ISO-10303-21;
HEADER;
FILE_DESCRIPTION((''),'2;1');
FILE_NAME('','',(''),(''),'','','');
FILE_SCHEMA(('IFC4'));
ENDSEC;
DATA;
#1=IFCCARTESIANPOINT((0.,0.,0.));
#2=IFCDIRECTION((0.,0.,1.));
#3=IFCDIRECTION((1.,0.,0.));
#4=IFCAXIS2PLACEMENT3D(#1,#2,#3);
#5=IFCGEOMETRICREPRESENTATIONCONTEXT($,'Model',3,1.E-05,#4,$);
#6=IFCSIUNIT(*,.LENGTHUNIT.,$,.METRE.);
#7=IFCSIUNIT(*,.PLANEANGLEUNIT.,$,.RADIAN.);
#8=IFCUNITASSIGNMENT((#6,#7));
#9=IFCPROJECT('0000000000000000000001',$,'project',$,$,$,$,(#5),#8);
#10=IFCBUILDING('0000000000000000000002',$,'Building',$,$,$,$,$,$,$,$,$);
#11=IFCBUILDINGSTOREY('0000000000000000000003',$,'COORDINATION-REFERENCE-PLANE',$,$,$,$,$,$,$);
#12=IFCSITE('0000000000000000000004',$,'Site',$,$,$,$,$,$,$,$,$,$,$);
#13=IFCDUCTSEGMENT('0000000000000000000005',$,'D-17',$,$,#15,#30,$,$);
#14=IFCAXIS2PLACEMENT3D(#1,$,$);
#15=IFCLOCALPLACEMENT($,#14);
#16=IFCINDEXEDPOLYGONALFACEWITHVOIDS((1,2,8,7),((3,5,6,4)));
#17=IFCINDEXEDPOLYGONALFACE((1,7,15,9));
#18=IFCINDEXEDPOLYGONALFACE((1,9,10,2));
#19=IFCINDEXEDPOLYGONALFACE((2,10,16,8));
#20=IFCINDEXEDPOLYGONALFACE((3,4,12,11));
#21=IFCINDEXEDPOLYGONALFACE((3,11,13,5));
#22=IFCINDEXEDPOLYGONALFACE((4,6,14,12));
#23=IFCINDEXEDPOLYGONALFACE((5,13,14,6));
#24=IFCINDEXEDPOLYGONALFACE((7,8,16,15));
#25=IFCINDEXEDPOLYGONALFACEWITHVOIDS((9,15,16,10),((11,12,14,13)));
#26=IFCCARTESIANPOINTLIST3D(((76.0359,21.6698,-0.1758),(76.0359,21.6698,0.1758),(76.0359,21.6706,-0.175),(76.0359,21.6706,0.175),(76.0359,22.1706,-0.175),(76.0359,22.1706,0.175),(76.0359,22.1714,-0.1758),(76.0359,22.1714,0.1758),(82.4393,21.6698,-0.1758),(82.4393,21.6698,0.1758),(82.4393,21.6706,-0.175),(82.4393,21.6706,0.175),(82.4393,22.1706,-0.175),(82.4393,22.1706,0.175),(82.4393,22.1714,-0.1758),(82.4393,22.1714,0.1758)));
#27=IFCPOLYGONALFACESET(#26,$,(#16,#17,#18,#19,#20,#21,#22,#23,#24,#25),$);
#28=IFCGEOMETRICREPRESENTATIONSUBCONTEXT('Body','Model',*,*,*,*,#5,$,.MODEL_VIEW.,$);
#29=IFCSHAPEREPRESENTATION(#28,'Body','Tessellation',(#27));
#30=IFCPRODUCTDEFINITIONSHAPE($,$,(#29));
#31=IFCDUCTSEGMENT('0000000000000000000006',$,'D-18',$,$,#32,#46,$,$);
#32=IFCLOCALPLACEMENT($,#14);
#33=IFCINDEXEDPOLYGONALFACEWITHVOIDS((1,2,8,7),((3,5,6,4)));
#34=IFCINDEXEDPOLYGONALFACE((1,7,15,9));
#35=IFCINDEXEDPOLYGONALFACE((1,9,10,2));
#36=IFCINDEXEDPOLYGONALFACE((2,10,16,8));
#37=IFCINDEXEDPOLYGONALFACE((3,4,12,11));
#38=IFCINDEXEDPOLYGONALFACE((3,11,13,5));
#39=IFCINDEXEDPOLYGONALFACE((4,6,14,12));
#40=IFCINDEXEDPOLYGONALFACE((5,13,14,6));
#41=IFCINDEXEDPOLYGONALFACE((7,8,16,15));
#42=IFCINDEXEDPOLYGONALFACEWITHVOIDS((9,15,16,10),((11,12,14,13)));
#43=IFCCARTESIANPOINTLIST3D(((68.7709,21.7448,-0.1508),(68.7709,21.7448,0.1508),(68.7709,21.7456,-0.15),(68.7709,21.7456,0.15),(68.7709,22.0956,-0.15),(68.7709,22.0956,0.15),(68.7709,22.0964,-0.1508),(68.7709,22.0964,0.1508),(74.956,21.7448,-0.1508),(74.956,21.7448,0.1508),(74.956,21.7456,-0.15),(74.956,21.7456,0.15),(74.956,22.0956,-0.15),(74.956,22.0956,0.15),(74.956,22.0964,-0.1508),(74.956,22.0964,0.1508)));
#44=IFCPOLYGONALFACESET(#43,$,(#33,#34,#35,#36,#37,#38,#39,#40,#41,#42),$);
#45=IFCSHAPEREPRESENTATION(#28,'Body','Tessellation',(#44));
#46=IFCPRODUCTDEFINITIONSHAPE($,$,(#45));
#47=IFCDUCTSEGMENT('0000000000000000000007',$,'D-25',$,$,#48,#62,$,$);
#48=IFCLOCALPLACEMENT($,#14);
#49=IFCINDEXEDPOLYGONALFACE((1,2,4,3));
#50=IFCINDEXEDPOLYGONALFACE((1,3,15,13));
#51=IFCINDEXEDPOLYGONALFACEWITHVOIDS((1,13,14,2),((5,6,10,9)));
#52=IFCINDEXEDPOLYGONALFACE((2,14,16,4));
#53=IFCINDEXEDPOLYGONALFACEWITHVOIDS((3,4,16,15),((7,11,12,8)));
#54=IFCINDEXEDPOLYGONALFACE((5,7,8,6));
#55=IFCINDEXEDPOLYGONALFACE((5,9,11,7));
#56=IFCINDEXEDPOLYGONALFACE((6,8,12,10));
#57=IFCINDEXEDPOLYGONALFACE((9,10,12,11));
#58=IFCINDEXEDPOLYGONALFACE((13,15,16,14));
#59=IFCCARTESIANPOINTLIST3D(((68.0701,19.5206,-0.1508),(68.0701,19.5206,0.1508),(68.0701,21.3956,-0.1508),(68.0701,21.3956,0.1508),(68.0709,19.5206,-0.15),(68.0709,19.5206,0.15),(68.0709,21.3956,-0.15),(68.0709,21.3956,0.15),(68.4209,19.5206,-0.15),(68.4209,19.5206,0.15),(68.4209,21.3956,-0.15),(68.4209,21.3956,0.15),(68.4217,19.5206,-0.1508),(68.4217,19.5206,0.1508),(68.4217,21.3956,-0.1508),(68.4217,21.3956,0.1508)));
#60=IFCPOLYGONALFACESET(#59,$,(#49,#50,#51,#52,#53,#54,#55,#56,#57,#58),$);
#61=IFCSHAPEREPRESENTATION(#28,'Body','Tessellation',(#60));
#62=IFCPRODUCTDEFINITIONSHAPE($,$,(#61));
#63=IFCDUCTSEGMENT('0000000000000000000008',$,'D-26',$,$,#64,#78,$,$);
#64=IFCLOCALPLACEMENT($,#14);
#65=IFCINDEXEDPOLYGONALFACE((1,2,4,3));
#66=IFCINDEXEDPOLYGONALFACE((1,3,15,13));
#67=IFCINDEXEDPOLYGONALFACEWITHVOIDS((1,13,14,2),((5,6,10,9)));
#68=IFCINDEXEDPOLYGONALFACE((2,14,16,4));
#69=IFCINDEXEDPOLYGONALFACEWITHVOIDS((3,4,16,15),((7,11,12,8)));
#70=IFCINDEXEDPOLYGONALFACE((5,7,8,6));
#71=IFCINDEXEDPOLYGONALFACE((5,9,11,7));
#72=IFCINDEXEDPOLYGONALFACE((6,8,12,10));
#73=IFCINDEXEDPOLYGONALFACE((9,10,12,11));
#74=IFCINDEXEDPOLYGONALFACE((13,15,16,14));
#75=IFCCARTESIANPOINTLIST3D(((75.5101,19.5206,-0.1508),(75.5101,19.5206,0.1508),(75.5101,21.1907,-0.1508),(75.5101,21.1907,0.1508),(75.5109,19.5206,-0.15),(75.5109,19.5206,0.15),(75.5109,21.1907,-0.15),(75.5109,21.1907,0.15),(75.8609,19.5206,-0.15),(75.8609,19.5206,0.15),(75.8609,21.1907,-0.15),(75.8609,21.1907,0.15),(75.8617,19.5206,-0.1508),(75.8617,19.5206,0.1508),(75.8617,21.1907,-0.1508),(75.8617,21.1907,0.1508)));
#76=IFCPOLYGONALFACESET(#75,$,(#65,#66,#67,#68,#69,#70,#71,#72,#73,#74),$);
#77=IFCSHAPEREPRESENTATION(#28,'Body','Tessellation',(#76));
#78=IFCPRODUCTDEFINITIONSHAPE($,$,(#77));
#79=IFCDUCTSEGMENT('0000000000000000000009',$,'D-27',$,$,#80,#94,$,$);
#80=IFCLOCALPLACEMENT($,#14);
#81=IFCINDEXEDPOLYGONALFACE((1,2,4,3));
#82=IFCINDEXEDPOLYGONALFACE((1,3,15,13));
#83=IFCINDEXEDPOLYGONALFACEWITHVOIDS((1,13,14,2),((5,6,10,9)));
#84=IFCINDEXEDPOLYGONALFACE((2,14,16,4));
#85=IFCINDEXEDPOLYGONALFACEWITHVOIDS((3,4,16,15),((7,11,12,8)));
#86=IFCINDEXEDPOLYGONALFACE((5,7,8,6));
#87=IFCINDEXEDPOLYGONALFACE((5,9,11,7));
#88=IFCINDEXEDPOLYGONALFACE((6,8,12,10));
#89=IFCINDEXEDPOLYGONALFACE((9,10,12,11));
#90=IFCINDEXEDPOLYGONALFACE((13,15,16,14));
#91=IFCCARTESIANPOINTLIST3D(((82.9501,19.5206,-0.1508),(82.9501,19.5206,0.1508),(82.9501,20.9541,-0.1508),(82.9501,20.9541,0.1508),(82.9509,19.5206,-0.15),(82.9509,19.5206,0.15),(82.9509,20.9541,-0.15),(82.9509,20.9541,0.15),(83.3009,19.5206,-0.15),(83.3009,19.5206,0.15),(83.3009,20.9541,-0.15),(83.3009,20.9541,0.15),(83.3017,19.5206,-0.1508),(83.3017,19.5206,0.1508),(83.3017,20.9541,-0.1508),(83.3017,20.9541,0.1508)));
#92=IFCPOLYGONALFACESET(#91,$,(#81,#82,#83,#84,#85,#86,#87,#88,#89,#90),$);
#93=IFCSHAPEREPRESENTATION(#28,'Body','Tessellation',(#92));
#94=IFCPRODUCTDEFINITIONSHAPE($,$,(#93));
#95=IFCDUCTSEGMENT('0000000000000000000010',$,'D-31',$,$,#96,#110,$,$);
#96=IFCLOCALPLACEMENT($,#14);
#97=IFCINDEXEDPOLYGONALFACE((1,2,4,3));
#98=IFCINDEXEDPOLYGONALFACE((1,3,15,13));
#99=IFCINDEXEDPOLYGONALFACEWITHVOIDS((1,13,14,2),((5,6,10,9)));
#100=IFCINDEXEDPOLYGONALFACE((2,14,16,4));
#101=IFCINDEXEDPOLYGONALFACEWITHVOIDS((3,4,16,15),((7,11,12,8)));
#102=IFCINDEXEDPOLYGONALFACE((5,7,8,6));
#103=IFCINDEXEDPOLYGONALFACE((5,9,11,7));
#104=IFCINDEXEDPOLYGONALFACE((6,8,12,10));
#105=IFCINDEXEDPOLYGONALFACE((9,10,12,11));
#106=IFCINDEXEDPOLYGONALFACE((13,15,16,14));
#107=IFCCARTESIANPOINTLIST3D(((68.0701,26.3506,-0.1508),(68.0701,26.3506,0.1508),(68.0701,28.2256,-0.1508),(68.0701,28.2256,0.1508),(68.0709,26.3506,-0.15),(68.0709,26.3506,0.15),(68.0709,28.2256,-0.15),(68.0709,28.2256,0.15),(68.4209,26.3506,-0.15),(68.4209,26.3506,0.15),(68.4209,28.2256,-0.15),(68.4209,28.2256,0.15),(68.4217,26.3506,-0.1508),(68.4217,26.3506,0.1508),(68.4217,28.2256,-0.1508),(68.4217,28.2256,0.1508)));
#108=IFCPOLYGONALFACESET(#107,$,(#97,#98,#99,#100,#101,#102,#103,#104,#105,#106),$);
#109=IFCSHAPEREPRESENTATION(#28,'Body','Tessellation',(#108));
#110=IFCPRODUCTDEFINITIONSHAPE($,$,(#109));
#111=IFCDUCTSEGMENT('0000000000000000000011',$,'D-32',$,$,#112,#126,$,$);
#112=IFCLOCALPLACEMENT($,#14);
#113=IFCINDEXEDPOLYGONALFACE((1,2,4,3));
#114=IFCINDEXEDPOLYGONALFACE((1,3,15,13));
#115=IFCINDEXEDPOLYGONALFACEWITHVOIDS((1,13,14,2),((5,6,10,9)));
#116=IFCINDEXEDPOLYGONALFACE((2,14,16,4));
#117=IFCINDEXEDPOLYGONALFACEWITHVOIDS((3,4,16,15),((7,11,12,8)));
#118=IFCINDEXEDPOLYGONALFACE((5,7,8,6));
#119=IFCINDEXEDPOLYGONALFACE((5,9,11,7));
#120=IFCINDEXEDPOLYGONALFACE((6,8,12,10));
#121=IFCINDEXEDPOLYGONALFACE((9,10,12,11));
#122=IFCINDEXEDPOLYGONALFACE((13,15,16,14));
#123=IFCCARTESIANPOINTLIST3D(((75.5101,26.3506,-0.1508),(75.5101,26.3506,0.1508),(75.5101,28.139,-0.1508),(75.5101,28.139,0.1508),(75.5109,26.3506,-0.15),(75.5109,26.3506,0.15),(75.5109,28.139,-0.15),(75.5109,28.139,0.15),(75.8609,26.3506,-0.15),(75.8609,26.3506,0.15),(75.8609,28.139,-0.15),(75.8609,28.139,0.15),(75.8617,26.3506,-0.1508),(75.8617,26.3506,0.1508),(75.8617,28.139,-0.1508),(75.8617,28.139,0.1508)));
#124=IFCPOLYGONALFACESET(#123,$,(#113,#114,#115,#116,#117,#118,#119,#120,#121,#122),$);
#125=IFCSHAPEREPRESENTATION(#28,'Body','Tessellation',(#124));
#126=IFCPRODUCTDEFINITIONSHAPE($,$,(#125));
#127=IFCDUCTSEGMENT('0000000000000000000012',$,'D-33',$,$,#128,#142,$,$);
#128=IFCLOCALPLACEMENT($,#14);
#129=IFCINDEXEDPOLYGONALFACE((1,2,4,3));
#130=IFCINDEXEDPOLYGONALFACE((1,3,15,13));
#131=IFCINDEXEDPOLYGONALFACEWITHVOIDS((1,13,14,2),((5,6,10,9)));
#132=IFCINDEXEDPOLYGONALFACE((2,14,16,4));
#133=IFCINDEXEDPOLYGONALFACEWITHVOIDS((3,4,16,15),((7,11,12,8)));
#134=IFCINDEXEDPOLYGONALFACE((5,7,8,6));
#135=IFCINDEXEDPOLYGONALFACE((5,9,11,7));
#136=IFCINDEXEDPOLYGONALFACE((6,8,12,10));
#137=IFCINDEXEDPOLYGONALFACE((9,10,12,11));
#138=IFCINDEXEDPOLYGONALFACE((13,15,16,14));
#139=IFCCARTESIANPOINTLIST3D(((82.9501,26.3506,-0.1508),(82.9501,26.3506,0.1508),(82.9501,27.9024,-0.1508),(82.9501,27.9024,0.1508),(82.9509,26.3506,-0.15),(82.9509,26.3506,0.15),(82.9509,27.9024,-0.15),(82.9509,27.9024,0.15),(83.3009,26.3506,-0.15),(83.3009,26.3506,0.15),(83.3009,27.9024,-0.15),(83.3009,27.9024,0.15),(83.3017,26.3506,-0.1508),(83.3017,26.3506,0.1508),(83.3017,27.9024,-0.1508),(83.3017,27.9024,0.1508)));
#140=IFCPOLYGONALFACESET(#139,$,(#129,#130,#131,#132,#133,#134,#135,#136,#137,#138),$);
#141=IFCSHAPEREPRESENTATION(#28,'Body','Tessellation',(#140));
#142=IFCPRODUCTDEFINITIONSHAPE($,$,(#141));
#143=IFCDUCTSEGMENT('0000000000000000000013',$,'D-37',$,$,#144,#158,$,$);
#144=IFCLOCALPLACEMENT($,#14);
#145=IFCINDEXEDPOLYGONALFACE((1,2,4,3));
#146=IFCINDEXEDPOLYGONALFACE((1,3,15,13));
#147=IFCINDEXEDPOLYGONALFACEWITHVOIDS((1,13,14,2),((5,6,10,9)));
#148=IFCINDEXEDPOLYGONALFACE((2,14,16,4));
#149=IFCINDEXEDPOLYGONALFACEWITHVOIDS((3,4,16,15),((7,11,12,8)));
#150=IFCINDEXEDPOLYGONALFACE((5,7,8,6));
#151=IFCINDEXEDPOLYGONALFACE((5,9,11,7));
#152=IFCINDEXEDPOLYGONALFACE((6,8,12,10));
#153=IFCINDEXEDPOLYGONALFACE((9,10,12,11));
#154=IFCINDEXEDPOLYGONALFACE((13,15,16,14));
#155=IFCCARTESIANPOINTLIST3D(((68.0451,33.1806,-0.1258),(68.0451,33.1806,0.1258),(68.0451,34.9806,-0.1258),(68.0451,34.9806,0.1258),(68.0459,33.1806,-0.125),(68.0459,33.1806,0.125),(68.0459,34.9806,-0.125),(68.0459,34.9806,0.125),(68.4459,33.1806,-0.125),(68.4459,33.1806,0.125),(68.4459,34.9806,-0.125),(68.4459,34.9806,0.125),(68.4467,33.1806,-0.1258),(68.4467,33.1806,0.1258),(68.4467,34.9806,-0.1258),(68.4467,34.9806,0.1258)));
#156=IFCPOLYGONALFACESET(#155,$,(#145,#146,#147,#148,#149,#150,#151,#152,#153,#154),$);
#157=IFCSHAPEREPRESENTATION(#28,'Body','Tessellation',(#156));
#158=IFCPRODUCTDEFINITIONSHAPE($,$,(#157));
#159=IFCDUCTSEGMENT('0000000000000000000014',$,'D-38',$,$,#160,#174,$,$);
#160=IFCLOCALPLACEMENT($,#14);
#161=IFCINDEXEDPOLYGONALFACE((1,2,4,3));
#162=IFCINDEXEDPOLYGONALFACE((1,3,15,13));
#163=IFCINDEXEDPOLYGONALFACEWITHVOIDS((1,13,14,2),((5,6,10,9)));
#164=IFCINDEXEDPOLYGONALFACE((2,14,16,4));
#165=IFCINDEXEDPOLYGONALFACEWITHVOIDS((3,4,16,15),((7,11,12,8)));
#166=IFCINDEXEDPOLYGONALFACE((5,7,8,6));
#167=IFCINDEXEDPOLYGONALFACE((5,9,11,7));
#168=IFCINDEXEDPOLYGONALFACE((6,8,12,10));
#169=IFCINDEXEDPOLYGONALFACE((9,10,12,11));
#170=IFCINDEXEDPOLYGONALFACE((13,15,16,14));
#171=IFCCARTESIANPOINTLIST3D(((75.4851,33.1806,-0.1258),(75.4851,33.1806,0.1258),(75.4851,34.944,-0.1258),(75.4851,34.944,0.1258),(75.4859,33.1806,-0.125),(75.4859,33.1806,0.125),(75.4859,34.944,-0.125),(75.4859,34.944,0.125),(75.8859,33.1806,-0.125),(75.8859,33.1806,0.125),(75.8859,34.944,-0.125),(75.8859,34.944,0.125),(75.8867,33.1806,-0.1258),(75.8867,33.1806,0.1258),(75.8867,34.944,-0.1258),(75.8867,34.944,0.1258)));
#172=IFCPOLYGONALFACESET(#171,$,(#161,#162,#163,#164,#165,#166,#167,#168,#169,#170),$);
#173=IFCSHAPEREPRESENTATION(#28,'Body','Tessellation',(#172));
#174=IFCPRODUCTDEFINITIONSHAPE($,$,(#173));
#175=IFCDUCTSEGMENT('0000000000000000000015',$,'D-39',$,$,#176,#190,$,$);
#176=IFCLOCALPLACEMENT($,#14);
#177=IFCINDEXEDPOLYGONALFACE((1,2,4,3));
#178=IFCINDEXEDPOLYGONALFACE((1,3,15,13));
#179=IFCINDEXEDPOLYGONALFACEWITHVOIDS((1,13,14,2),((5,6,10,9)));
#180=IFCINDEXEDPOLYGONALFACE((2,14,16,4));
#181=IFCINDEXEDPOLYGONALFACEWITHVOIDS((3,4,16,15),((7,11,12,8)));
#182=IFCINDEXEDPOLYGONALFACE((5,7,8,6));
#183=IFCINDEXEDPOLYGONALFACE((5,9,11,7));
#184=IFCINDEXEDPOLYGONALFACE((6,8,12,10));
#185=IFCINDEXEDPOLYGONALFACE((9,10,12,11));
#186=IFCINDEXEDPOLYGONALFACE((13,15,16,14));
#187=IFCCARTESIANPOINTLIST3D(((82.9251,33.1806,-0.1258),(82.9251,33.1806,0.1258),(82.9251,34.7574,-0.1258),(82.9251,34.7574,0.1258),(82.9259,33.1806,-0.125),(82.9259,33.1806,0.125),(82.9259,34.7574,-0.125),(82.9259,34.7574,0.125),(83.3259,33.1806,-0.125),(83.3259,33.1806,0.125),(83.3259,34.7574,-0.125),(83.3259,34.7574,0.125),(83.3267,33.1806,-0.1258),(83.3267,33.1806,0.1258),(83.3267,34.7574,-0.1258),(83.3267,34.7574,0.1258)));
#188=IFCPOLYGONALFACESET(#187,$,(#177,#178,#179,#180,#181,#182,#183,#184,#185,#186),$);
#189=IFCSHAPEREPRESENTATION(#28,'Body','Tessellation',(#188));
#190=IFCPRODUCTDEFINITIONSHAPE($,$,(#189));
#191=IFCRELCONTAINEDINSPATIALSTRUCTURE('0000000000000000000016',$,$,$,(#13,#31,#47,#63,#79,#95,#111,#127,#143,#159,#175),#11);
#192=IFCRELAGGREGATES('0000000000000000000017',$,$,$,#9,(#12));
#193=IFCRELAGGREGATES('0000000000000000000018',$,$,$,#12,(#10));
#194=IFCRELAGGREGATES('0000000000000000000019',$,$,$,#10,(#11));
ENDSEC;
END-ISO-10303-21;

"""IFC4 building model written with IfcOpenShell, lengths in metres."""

from ifc_helpers import new_model, si_unit, frame, origin, origin_with_axes, place, context, subcontext, project, spatial, hollow_rectangle, extrude, element, save


model = new_model("IFC4")

# Units and contexts
model_context = context("Model", 3, precision=1e-05, world=origin_with_axes())
body_context = subcontext(model_context, "Body", "Model", "MODEL_VIEW")
ifc_project = project(units=[si_unit("LENGTHUNIT", "METRE"), si_unit("PLANEANGLEUNIT", "RADIAN")], contexts=[model_context])

# Site, building, storey
site = spatial("IfcSite", under=ifc_project, Name="Site")
building = spatial("IfcBuilding", under=site, Name="Building")
storey = spatial("IfcBuildingStorey", under=building, Name="COORDINATION-REFERENCE-PLANE")

# Duct segments
duct_segment_1_placement = place(None, frame((76.0359, 21.9206, 0.0), z_axis=(1.0, 0.0, 0.0), x_axis=(0.0, 1.0, 0.0)))
element("IfcDuctSegment", 1, at=duct_segment_1_placement, inside=storey, Name="D-17", context=body_context, shape_type="SweptSolid", body=[
    extrude(hollow_rectangle(XDim=0.5016, YDim=0.3516, WallThickness=0.0008), origin(), (0.0, 0.0, 1.0), 6.4034),
])
duct_segment_2_placement = place(None, frame((68.7709, 21.9206, 0.0), z_axis=(1.0, 0.0, 0.0), x_axis=(0.0, 1.0, 0.0)))
element("IfcDuctSegment", 2, at=duct_segment_2_placement, inside=storey, Name="D-18", context=body_context, shape_type="SweptSolid", body=[
    extrude(hollow_rectangle(XDim=0.3516, YDim=0.3016, WallThickness=0.0008), origin(), (0.0, 0.0, 1.0), 6.1851),
])
duct_segment_3_placement = place(None, frame((68.2459, 19.5206, 0.0), z_axis=(0.0, 1.0, 0.0), x_axis=(1.0, 0.0, 0.0)))
element("IfcDuctSegment", 3, at=duct_segment_3_placement, inside=storey, Name="D-25", context=body_context, shape_type="SweptSolid", body=[
    extrude(hollow_rectangle(XDim=0.3516, YDim=0.3016, WallThickness=0.0008), origin(), (0.0, 0.0, 1.0), 1.875),
])
duct_segment_4_placement = place(None, frame((75.6859, 19.5206, 0.0), z_axis=(0.0, 1.0, 0.0), x_axis=(1.0, 0.0, 0.0)))
element("IfcDuctSegment", 4, at=duct_segment_4_placement, inside=storey, Name="D-26", context=body_context, shape_type="SweptSolid", body=[
    extrude(hollow_rectangle(XDim=0.3516, YDim=0.3016, WallThickness=0.0008), origin(), (0.0, 0.0, 1.0), 1.6701),
])
duct_segment_5_placement = place(None, frame((83.1259, 19.5206, 0.0), z_axis=(0.0, 1.0, 0.0), x_axis=(1.0, 0.0, 0.0)))
element("IfcDuctSegment", 5, at=duct_segment_5_placement, inside=storey, Name="D-27", context=body_context, shape_type="SweptSolid", body=[
    extrude(hollow_rectangle(XDim=0.3516, YDim=0.3016, WallThickness=0.0008), origin(), (0.0, 0.0, 1.0), 1.4335),
])
duct_segment_6_placement = place(None, frame((68.2459, 26.3506, 0.0), z_axis=(0.0, 1.0, 0.0), x_axis=(1.0, 0.0, 0.0)))
element("IfcDuctSegment", 6, at=duct_segment_6_placement, inside=storey, Name="D-31", context=body_context, shape_type="SweptSolid", body=[
    extrude(hollow_rectangle(XDim=0.3516, YDim=0.3016, WallThickness=0.0008), origin(), (0.0, 0.0, 1.0), 1.875),
])
duct_segment_7_placement = place(None, frame((75.6859, 26.3506, 0.0), z_axis=(0.0, 1.0, 0.0), x_axis=(1.0, 0.0, 0.0)))
element("IfcDuctSegment", 7, at=duct_segment_7_placement, inside=storey, Name="D-32", context=body_context, shape_type="SweptSolid", body=[
    extrude(hollow_rectangle(XDim=0.3516, YDim=0.3016, WallThickness=0.0008), origin(), (0.0, 0.0, 1.0), 1.7884),
])
duct_segment_8_placement = place(None, frame((83.1259, 26.3506, 0.0), z_axis=(0.0, 1.0, 0.0), x_axis=(1.0, 0.0, 0.0)))
element("IfcDuctSegment", 8, at=duct_segment_8_placement, inside=storey, Name="D-33", context=body_context, shape_type="SweptSolid", body=[
    extrude(hollow_rectangle(XDim=0.3516, YDim=0.3016, WallThickness=0.0008), origin(), (0.0, 0.0, 1.0), 1.5518),
])
duct_segment_9_placement = place(None, frame((68.2459, 33.1806, 0.0), z_axis=(0.0, 1.0, 0.0), x_axis=(1.0, 0.0, 0.0)))
element("IfcDuctSegment", 9, at=duct_segment_9_placement, inside=storey, Name="D-37", context=body_context, shape_type="SweptSolid", body=[
    extrude(hollow_rectangle(XDim=0.4016, YDim=0.2516, WallThickness=0.0008), origin(), (0.0, 0.0, 1.0), 1.8),
])
duct_segment_10_placement = place(None, frame((75.6859, 33.1806, 0.0), z_axis=(0.0, 1.0, 0.0), x_axis=(1.0, 0.0, 0.0)))
element("IfcDuctSegment", 10, at=duct_segment_10_placement, inside=storey, Name="D-38", context=body_context, shape_type="SweptSolid", body=[
    extrude(hollow_rectangle(XDim=0.4016, YDim=0.2516, WallThickness=0.0008), origin(), (0.0, 0.0, 1.0), 1.7634),
])
duct_segment_11_placement = place(None, frame((83.1259, 33.1806, 0.0), z_axis=(0.0, 1.0, 0.0), x_axis=(1.0, 0.0, 0.0)))
element("IfcDuctSegment", 11, at=duct_segment_11_placement, inside=storey, Name="D-39", context=body_context, shape_type="SweptSolid", body=[
    extrude(hollow_rectangle(XDim=0.4016, YDim=0.2516, WallThickness=0.0008), origin(), (0.0, 0.0, 1.0), 1.5768),
])

save(model, "model.ifc")
